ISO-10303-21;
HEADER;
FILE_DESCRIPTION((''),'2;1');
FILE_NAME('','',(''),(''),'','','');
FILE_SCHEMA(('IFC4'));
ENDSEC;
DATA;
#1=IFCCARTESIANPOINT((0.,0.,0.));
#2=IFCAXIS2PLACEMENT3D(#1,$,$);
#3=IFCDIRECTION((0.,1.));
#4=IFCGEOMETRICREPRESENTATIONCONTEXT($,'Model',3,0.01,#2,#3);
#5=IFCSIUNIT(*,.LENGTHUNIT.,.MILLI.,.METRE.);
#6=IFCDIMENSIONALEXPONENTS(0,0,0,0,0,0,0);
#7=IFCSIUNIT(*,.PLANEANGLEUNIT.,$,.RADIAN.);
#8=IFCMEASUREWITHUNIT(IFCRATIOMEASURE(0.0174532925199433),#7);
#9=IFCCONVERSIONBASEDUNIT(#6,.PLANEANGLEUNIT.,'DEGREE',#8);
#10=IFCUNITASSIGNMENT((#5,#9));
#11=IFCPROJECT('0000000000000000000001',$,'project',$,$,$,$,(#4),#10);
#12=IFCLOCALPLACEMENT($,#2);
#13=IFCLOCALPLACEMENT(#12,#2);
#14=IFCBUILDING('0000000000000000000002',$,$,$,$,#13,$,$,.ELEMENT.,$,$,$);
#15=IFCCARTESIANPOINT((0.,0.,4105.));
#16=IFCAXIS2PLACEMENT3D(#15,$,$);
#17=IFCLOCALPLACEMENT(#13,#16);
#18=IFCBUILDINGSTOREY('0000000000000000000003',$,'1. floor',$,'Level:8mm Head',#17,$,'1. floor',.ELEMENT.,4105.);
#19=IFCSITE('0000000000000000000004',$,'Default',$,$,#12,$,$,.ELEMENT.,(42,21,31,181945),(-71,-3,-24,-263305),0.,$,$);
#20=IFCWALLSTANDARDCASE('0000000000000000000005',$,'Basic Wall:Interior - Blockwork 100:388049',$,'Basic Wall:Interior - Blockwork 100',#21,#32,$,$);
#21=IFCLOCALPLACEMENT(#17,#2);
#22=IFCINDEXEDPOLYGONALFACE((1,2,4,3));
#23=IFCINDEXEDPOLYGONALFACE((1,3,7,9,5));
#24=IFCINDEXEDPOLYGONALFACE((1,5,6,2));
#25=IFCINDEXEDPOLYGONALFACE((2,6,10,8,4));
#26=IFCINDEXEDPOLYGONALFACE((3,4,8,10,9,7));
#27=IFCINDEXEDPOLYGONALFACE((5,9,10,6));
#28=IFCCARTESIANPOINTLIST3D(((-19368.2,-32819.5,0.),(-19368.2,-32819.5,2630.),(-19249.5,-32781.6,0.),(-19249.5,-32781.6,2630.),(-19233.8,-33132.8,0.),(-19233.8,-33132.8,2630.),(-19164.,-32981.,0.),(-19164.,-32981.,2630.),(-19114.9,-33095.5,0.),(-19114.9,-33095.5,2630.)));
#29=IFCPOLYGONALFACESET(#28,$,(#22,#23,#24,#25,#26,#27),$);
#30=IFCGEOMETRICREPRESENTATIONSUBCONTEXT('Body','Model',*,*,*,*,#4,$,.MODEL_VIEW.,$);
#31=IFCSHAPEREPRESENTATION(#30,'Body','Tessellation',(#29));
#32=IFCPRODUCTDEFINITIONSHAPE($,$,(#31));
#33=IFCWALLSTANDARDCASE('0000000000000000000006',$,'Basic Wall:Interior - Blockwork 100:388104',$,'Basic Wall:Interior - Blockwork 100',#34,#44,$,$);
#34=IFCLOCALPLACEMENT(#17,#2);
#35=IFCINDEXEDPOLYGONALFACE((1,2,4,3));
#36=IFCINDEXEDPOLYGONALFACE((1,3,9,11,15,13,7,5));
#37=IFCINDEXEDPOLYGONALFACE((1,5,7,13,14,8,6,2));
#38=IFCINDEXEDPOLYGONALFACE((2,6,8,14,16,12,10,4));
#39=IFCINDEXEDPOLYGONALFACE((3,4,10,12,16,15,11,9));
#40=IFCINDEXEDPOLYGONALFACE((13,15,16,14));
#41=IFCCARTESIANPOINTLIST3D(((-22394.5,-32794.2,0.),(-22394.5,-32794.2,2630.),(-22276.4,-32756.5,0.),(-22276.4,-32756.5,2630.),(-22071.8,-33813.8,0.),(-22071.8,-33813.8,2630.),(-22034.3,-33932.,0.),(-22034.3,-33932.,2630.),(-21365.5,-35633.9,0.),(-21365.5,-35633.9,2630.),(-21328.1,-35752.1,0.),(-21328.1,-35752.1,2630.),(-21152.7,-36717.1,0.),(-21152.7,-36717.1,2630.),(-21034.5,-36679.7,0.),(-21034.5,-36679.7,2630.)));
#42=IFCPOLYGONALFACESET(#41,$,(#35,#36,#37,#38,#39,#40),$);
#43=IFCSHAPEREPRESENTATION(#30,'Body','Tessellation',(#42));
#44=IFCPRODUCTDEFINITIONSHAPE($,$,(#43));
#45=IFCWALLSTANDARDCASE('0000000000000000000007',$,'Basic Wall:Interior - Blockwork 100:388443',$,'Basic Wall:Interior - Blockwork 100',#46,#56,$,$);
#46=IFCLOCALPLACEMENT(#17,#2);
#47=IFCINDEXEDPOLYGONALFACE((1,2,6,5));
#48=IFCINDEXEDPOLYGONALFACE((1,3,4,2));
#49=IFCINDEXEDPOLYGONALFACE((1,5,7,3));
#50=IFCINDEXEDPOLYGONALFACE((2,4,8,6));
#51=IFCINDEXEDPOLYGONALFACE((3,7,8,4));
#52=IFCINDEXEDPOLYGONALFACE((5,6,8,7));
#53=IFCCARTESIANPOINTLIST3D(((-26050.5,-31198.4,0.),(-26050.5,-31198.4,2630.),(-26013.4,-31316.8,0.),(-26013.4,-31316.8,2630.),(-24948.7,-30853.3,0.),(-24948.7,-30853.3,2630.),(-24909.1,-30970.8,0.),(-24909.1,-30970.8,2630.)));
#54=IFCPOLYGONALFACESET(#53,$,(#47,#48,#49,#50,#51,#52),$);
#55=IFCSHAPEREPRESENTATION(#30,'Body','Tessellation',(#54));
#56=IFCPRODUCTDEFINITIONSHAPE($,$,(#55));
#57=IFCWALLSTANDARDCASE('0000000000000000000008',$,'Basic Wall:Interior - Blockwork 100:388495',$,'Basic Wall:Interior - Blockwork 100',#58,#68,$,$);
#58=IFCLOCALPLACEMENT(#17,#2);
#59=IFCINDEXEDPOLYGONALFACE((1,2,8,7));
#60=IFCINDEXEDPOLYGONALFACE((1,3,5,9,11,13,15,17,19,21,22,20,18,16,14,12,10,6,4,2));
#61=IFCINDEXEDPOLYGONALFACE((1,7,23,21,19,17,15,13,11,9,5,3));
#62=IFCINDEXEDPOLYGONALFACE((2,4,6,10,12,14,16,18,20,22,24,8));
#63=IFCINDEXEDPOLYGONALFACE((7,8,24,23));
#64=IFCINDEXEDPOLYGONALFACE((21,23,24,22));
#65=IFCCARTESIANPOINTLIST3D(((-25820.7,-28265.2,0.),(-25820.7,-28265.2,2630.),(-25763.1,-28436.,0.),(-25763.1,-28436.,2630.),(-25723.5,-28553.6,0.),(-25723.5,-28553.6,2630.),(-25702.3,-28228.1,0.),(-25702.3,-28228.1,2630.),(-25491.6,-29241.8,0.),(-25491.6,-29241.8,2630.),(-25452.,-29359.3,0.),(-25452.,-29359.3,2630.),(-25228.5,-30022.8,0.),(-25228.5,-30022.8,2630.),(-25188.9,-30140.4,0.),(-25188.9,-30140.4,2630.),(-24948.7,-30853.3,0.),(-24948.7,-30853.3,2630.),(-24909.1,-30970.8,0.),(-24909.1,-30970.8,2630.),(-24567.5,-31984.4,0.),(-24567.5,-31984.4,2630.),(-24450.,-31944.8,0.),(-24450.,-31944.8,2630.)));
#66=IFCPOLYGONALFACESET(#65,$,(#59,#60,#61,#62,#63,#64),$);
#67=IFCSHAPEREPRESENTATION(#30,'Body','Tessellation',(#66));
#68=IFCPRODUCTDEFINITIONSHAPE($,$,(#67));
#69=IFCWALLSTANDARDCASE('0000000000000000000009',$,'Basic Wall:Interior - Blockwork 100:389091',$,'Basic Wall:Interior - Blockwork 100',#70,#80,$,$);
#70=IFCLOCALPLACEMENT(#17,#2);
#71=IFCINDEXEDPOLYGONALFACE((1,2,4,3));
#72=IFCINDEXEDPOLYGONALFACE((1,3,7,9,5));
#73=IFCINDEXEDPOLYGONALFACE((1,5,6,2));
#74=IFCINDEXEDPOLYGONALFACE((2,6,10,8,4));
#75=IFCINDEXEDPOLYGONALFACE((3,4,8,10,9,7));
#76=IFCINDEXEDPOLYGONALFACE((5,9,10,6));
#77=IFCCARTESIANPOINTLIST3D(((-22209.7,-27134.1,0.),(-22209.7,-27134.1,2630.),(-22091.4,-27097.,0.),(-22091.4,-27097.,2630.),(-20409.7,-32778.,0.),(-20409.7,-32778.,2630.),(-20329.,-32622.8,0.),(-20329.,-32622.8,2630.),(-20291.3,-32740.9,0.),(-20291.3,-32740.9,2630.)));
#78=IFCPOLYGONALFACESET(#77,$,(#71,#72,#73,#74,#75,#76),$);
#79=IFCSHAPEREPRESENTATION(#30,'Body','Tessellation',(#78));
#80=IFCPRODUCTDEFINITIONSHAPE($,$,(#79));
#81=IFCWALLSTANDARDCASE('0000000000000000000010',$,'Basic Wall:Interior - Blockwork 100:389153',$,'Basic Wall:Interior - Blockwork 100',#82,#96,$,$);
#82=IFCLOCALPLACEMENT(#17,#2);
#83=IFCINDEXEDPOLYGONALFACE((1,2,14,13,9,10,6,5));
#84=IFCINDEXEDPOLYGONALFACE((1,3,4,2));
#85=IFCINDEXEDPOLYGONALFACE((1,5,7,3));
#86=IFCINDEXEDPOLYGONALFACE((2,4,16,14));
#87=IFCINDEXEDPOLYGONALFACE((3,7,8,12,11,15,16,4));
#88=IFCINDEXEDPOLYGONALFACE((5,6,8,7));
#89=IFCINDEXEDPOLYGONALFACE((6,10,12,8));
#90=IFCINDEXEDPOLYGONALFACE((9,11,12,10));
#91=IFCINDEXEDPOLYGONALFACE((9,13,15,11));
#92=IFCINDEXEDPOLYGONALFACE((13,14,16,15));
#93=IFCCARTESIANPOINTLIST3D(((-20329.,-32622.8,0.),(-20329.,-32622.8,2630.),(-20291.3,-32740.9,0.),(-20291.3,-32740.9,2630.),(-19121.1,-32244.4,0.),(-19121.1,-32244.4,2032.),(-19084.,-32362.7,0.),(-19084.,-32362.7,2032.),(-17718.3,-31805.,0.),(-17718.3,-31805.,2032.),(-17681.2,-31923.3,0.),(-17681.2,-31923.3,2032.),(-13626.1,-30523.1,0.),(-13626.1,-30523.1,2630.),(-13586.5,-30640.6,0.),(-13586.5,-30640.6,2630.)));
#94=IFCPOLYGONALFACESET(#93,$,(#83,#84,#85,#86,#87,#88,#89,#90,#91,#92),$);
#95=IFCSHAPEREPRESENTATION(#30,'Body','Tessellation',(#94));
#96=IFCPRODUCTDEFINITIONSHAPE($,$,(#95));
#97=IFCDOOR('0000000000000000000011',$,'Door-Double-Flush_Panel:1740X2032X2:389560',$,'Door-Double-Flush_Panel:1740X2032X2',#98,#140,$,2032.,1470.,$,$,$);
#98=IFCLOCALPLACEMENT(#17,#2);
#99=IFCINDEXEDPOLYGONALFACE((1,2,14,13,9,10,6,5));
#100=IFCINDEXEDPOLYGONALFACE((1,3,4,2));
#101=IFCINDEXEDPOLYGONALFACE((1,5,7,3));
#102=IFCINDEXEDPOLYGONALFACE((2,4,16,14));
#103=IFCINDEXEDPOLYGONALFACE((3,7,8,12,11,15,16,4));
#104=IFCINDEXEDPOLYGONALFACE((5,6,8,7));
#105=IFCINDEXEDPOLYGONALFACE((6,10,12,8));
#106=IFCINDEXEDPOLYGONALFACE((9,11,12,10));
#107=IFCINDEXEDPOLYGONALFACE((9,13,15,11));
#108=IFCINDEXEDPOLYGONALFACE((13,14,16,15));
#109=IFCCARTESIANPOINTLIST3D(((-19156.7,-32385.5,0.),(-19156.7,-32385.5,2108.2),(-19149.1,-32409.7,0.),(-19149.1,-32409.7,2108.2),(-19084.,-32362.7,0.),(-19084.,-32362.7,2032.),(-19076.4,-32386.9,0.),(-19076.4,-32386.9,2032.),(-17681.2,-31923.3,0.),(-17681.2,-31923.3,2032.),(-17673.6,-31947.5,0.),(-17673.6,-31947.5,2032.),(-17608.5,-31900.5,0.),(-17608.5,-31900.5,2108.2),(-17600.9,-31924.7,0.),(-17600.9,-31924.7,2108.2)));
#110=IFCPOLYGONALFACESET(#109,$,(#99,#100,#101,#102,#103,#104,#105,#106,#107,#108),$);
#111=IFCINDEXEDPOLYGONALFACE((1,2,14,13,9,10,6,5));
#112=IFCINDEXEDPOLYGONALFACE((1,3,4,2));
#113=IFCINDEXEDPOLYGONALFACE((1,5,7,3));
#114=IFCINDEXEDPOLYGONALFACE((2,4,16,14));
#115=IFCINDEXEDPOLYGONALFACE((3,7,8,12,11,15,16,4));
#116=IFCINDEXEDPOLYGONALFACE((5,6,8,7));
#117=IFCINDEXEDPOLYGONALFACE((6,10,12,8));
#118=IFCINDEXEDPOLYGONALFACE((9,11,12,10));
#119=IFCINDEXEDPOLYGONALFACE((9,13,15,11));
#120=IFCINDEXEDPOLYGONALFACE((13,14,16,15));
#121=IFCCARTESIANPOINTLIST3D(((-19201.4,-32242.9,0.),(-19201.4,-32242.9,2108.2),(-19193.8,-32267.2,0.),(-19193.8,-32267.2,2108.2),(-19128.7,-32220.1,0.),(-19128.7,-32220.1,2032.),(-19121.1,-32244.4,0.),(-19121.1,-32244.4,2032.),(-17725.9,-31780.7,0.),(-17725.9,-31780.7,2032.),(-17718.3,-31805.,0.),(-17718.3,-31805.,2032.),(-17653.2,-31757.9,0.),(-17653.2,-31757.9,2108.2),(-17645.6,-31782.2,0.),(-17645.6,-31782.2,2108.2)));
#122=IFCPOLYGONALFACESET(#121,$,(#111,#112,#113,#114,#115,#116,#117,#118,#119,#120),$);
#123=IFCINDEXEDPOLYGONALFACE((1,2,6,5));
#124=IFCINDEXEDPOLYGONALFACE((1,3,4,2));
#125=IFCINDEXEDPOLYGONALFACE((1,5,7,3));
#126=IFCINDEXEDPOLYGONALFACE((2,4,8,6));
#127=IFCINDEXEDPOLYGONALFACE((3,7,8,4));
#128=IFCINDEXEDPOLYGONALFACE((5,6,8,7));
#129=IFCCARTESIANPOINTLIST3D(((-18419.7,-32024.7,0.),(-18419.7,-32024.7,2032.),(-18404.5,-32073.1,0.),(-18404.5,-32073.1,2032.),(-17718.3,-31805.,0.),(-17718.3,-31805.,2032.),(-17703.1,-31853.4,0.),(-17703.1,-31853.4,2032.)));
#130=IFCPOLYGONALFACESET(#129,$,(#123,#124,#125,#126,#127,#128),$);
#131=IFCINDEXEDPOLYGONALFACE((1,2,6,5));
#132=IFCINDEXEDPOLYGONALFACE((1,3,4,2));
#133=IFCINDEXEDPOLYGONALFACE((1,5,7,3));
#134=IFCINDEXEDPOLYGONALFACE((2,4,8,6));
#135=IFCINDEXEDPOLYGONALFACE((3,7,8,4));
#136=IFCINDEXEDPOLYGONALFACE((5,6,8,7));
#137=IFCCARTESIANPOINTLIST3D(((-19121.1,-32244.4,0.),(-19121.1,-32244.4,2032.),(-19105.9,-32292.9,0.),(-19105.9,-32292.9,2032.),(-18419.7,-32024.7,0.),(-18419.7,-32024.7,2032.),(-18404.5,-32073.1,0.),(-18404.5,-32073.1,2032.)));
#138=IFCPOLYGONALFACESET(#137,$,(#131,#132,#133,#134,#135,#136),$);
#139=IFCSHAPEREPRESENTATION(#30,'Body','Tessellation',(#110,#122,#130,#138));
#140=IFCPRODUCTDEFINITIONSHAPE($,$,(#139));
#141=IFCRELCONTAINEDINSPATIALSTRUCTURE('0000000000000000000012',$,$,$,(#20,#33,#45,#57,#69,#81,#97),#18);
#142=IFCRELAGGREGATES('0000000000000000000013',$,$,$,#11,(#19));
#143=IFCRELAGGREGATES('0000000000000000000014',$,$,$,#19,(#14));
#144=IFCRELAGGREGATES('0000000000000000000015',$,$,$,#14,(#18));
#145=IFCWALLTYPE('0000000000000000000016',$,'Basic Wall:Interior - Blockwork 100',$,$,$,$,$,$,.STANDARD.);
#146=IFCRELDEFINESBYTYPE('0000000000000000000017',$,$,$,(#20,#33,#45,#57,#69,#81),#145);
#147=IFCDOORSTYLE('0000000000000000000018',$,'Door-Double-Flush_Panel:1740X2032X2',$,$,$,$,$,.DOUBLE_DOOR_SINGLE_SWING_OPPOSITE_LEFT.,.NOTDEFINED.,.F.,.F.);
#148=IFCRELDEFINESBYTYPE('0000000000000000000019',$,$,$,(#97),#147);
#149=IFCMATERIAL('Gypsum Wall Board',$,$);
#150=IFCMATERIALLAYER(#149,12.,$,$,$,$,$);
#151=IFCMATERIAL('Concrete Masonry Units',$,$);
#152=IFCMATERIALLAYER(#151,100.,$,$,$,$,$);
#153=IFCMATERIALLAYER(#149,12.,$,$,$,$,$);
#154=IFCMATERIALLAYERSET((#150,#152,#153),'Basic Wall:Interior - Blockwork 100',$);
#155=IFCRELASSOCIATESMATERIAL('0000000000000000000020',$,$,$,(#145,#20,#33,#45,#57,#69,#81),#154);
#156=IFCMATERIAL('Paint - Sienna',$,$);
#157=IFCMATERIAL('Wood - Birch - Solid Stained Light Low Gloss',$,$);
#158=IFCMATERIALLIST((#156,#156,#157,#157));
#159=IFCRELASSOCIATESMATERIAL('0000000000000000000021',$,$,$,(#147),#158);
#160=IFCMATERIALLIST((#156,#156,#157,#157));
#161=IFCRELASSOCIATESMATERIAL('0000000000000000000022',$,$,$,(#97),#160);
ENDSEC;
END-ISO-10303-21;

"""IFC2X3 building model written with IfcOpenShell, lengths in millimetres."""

from ifc_helpers import new_model, entity, si_unit, converted_unit, direction, frame, frame_2d, origin, origin_2d_with_axis, place, context, subcontext, project, spatial, polyline, rectangle, outline, extrude, source, transform, mapped, material, material_list, layer, layer_set, layer_usage, type_object, type_shapes, element, fill, save


model = new_model("IFC2X3")

# Units and contexts
model_context = context("Model", 3, precision=0.01, world=origin(), true_north=direction((0.0, 1.0)))
body_context = subcontext(model_context, "Body", "Model", "MODEL_VIEW")
ifc_project = project(units=[si_unit("LENGTHUNIT", "METRE", prefix="MILLI"), converted_unit("PLANEANGLEUNIT", "DEGREE", entity("IfcRatioMeasure", 0.0174532925199433), si_unit("PLANEANGLEUNIT", "RADIAN"), dimensions=[0, 0, 0, 0, 0, 0, 0])], contexts=[model_context])

# Site, building, storey
site_placement = place(None, origin())
site = spatial("IfcSite", under=ifc_project, at=site_placement, Name="Default", CompositionType="ELEMENT", RefLatitude=(42, 21, 31, 181945), RefLongitude=(-71, -3, -24, -263305), RefElevation=0.0)
building_placement = place(site_placement, origin())
building = spatial("IfcBuilding", under=site, at=building_placement, CompositionType="ELEMENT")
storey_placement = place(building_placement, frame((0.0, 0.0, 4105.0)))
storey = spatial("IfcBuildingStorey", under=building, at=storey_placement, Name="1. floor", ObjectType="Level:8mm Head", LongName="1. floor", CompositionType="ELEMENT", Elevation=4105.0)

# Shared definitions
ifc_material_1 = material(Name="Gypsum Wall Board")
ifc_layer_1 = layer(ifc_material_1, 12.0)
ifc_material_2 = material(Name="Concrete Masonry Units")
ifc_layer_2 = layer(ifc_material_2, 100.0)
ifc_layer_3 = layer(ifc_material_1, 12.0)
ifc_layer_set = layer_set([ifc_layer_1, ifc_layer_2, ifc_layer_3], Name="Basic Wall:Interior - Blockwork 100")
wall_type = type_object("IfcWallType", Name="Basic Wall:Interior - Blockwork 100", PredefinedType="STANDARD", material=ifc_layer_set)

# Walls
ifc_layer_usage_1 = layer_usage(ifc_layer_set, "AXIS2", "NEGATIVE", 62.0)
wall_1_placement = place(storey_placement, frame((-19311.3, -32795.0, 0.0), z_axis=(0.0, 0.0, 1.0), x_axis=(0.394208, -0.919021, 0.0)))
element("IfcWallStandardCase", 1, at=wall_1_placement, inside=storey, type_object=wall_type, material=ifc_layer_usage_1, Name="Basic Wall:Interior - Blockwork 100:388049", ObjectType="Basic Wall:Interior - Blockwork 100", context=body_context, shape_type="SweptSolid", body=[
    extrude(outline(polyline([(340.9, -62.0), (353.6, 62.0), (228.9, 62.0), (12.0, 62.0), (0.0, -62.0), (340.9, -62.0)])), origin(), (0.0, 0.0, 1.0), 2630.0),
])
ifc_layer_usage_2 = layer_usage(ifc_layer_set, "AXIS2", "NEGATIVE", 62.0)
wall_2_placement = place(storey_placement, frame((-22335.5, -32775.2, 0.0), z_axis=(0.0, 0.0, 1.0), x_axis=(0.301797, -0.953372, 0.0)))
element("IfcWallStandardCase", 2, at=wall_2_placement, inside=storey, type_object=wall_type, material=ifc_layer_usage_2, Name="Basic Wall:Interior - Blockwork 100:388104", ObjectType="Basic Wall:Interior - Blockwork 100", context=body_context, shape_type="SweptSolid", body=[
    extrude(outline(polyline([(4115.0, -62.0), (4115.0, 62.0), (3142.1, 62.0), (3018.1, 62.0), (0.0, 62.0), (0.3, -62.0), (1069.7, -62.0), (1193.7, -62.0), (4115.0, -62.0)])), origin(), (0.0, 0.0, 1.0), 2630.0),
])
ifc_layer_usage_3 = layer_usage(ifc_layer_set, "AXIS2", "NEGATIVE", 62.0)
wall_3_placement = place(storey_placement, frame((-26031.9, -31257.6, 0.0), z_axis=(0.0, 0.0, 1.0), x_axis=(0.954277, 0.298924, 0.0)))
element("IfcWallStandardCase", 3, at=wall_3_placement, inside=storey, type_object=wall_type, material=ifc_layer_usage_3, Name="Basic Wall:Interior - Blockwork 100:388443", ObjectType="Basic Wall:Interior - Blockwork 100", context=body_context, shape_type="SweptSolid", body=[
    extrude(outline(polyline([(1157.3, -62.0), (1154.6, 62.0), (0.0, 62.0), (0.0, -62.0), (1157.3, -62.0)])), origin(), (0.0, 0.0, 1.0), 2630.0),
])
ifc_layer_usage_4 = layer_usage(ifc_layer_set, "AXIS2", "NEGATIVE", 62.0)
wall_4_placement = place(storey_placement, frame((-25761.9, -28245.4, 0.0), z_axis=(0.0, 0.0, 1.0), x_axis=(0.319293, -0.947656, 0.0)))
element("IfcWallStandardCase", 4, at=wall_4_placement, inside=storey, type_object=wall_type, material=ifc_layer_usage_4, Name="Basic Wall:Interior - Blockwork 100:388495", ObjectType="Basic Wall:Interior - Blockwork 100", context=body_context, shape_type="SweptSolid", body=[
    extrude(outline(polyline([(3924.7, -62.0), (3924.7, 62.0), (2.7, 62.0), (0.0, -62.0), (180.3, -62.0), (304.3, -62.0), (1030.6, -62.0), (1154.6, -62.0), (1854.7, -62.0), (1978.8, -62.0), (2731.1, -62.0), (2855.1, -62.0), (3924.7, -62.0)])), origin(), (0.0, 0.0, 1.0), 2630.0),
])
ifc_layer_usage_5 = layer_usage(ifc_layer_set, "AXIS2", "NEGATIVE", 62.0)
wall_5_placement = place(storey_placement, frame((-22150.6, -27115.2, 0.0), z_axis=(0.0, 0.0, 1.0), x_axis=(0.303856, -0.952718, 0.0)))
element("IfcWallStandardCase", 5, at=wall_5_placement, inside=storey, type_object=wall_type, material=ifc_layer_usage_5, Name="Basic Wall:Interior - Blockwork 100:389091", ObjectType="Basic Wall:Interior - Blockwork 100", context=body_context, shape_type="SweptSolid", body=[
    extrude(outline(polyline([(5924.0, -62.0), (5924.6, 62.0), (5800.6, 62.0), (0.6, 62.0), (0.0, -62.0), (5924.0, -62.0)])), origin(), (0.0, 0.0, 1.0), 2630.0),
])

# Wall, opening, door
ifc_layer_usage_6 = layer_usage(ifc_layer_set, "AXIS2", "NEGATIVE", 62.0)
wall_6_placement = place(storey_placement, frame((-20310.5, -32681.9, 0.0), z_axis=(0.0, 0.0, 1.0), x_axis=(0.954277, 0.298924, 0.0)))
wall_6 = element("IfcWallStandardCase", 6, at=wall_6_placement, inside=storey, type_object=wall_type, material=ifc_layer_usage_6, Name="Basic Wall:Interior - Blockwork 100:389153", ObjectType="Basic Wall:Interior - Blockwork 100", context=body_context, shape_type="SweptSolid", body=[
    extrude(outline(polyline([(0.6, -62.0), (7026.7, -62.0), (7024.0, 62.0), (6900.0, 62.0), (0.0, 62.0), (0.6, -62.0)])), origin(), (0.0, 0.0, 1.0), 2630.0),
])
opening_1_placement = place(wall_6_placement, frame((1265.8, -62.0, 0.0)))
opening_1 = element("IfcOpeningElement", 7, at=opening_1_placement, cuts=wall_6, ObjectType="Opening", context=body_context, shape_type="SweptSolid", body=[
    extrude(rectangle(XDim=2032.0, YDim=1470.0, at=frame_2d((1016.0, 735.0), x_axis=(1.0, 0.0))), frame((0.0, 0.0, 0.0), z_axis=(0.0, 1.0, 0.0), x_axis=(0.0, 0.0, 1.0)), (0.0, 0.0, 1.0), 124.0),
])
ifc_material_3 = material(Name="Paint - Sienna")
ifc_material_4 = material(Name="Wood - Birch - Solid Stained Light Low Gloss")
ifc_material_list_1 = material_list([ifc_material_3, ifc_material_3, ifc_material_4, ifc_material_4])
ifc_material_list_2 = material_list([ifc_material_3, ifc_material_3, ifc_material_4, ifc_material_4])
door_style_1 = type_object("IfcDoorStyle", Name="Door-Double-Flush_Panel:1740X2032X2", ConstructionType="NOTDEFINED", OperationType="DOUBLE_DOOR_SINGLE_SWING_OPPOSITE_LEFT", ParameterTakesPrecedence=False, Sizeable=False, material=ifc_material_list_2)
shared_shape_1 = source(origin(), body_context, "Body", "SweptSolid", [
    extrude(outline(polyline([(-997.0, 735.0), (1035.0, 735.0), (1035.0, 811.2), (-1073.2, 811.2), (-1073.2, -811.2), (1035.0, -811.2), (1035.0, -735.0), (-997.0, -735.0), (-997.0, 735.0)])), frame((735.0, -25.4, 1035.0), z_axis=(0.0, 1.0, 0.0), x_axis=(0.0, 0.0, -1.0)), (0.0, 0.0, 1.0), 25.4),
    extrude(outline(polyline([(-997.0, 735.0), (1035.0, 735.0), (1035.0, 811.2), (-1073.2, 811.2), (-1073.2, -811.2), (1035.0, -811.2), (1035.0, -735.0), (-997.0, -735.0), (-997.0, 735.0)])), frame((735.0, 124.0, 1035.0), z_axis=(0.0, 1.0, 0.0), x_axis=(0.0, 0.0, -1.0)), (0.0, 0.0, 1.0), 25.4),
    extrude(rectangle(XDim=50.8, YDim=735.0, at=frame_2d((0.0, 0.0), x_axis=(1.0, 0.0))), frame((1102.5, 98.6, 0.0), z_axis=(0.0, 0.0, 1.0), x_axis=(0.0, -1.0, 0.0)), (0.0, 0.0, 1.0), 2032.0),
    extrude(rectangle(XDim=50.8, YDim=735.0, at=origin_2d_with_axis()), frame((367.5, 98.6, 0.0), z_axis=(0.0, 0.0, 1.0), x_axis=(0.0, -1.0, 0.0)), (0.0, 0.0, 1.0), 2032.0),
])
type_shapes(door_style_1, [shared_shape_1])
door_1_placement = place(opening_1_placement, origin())
door_1 = element("IfcDoor", 8, at=door_1_placement, inside=storey, type_object=door_style_1, material=ifc_material_list_1, Name="Door-Double-Flush_Panel:1740X2032X2:389560", ObjectType="Door-Double-Flush_Panel:1740X2032X2", OverallHeight=2032.0, OverallWidth=1470.0, context=body_context, shape_type="MappedRepresentation", body=[
    mapped(shared_shape_1, transform((0.0, 0.0, 0.0), scale=1.0)),
])
fill(opening_1, door_1)

save(model, "model.ifc")
